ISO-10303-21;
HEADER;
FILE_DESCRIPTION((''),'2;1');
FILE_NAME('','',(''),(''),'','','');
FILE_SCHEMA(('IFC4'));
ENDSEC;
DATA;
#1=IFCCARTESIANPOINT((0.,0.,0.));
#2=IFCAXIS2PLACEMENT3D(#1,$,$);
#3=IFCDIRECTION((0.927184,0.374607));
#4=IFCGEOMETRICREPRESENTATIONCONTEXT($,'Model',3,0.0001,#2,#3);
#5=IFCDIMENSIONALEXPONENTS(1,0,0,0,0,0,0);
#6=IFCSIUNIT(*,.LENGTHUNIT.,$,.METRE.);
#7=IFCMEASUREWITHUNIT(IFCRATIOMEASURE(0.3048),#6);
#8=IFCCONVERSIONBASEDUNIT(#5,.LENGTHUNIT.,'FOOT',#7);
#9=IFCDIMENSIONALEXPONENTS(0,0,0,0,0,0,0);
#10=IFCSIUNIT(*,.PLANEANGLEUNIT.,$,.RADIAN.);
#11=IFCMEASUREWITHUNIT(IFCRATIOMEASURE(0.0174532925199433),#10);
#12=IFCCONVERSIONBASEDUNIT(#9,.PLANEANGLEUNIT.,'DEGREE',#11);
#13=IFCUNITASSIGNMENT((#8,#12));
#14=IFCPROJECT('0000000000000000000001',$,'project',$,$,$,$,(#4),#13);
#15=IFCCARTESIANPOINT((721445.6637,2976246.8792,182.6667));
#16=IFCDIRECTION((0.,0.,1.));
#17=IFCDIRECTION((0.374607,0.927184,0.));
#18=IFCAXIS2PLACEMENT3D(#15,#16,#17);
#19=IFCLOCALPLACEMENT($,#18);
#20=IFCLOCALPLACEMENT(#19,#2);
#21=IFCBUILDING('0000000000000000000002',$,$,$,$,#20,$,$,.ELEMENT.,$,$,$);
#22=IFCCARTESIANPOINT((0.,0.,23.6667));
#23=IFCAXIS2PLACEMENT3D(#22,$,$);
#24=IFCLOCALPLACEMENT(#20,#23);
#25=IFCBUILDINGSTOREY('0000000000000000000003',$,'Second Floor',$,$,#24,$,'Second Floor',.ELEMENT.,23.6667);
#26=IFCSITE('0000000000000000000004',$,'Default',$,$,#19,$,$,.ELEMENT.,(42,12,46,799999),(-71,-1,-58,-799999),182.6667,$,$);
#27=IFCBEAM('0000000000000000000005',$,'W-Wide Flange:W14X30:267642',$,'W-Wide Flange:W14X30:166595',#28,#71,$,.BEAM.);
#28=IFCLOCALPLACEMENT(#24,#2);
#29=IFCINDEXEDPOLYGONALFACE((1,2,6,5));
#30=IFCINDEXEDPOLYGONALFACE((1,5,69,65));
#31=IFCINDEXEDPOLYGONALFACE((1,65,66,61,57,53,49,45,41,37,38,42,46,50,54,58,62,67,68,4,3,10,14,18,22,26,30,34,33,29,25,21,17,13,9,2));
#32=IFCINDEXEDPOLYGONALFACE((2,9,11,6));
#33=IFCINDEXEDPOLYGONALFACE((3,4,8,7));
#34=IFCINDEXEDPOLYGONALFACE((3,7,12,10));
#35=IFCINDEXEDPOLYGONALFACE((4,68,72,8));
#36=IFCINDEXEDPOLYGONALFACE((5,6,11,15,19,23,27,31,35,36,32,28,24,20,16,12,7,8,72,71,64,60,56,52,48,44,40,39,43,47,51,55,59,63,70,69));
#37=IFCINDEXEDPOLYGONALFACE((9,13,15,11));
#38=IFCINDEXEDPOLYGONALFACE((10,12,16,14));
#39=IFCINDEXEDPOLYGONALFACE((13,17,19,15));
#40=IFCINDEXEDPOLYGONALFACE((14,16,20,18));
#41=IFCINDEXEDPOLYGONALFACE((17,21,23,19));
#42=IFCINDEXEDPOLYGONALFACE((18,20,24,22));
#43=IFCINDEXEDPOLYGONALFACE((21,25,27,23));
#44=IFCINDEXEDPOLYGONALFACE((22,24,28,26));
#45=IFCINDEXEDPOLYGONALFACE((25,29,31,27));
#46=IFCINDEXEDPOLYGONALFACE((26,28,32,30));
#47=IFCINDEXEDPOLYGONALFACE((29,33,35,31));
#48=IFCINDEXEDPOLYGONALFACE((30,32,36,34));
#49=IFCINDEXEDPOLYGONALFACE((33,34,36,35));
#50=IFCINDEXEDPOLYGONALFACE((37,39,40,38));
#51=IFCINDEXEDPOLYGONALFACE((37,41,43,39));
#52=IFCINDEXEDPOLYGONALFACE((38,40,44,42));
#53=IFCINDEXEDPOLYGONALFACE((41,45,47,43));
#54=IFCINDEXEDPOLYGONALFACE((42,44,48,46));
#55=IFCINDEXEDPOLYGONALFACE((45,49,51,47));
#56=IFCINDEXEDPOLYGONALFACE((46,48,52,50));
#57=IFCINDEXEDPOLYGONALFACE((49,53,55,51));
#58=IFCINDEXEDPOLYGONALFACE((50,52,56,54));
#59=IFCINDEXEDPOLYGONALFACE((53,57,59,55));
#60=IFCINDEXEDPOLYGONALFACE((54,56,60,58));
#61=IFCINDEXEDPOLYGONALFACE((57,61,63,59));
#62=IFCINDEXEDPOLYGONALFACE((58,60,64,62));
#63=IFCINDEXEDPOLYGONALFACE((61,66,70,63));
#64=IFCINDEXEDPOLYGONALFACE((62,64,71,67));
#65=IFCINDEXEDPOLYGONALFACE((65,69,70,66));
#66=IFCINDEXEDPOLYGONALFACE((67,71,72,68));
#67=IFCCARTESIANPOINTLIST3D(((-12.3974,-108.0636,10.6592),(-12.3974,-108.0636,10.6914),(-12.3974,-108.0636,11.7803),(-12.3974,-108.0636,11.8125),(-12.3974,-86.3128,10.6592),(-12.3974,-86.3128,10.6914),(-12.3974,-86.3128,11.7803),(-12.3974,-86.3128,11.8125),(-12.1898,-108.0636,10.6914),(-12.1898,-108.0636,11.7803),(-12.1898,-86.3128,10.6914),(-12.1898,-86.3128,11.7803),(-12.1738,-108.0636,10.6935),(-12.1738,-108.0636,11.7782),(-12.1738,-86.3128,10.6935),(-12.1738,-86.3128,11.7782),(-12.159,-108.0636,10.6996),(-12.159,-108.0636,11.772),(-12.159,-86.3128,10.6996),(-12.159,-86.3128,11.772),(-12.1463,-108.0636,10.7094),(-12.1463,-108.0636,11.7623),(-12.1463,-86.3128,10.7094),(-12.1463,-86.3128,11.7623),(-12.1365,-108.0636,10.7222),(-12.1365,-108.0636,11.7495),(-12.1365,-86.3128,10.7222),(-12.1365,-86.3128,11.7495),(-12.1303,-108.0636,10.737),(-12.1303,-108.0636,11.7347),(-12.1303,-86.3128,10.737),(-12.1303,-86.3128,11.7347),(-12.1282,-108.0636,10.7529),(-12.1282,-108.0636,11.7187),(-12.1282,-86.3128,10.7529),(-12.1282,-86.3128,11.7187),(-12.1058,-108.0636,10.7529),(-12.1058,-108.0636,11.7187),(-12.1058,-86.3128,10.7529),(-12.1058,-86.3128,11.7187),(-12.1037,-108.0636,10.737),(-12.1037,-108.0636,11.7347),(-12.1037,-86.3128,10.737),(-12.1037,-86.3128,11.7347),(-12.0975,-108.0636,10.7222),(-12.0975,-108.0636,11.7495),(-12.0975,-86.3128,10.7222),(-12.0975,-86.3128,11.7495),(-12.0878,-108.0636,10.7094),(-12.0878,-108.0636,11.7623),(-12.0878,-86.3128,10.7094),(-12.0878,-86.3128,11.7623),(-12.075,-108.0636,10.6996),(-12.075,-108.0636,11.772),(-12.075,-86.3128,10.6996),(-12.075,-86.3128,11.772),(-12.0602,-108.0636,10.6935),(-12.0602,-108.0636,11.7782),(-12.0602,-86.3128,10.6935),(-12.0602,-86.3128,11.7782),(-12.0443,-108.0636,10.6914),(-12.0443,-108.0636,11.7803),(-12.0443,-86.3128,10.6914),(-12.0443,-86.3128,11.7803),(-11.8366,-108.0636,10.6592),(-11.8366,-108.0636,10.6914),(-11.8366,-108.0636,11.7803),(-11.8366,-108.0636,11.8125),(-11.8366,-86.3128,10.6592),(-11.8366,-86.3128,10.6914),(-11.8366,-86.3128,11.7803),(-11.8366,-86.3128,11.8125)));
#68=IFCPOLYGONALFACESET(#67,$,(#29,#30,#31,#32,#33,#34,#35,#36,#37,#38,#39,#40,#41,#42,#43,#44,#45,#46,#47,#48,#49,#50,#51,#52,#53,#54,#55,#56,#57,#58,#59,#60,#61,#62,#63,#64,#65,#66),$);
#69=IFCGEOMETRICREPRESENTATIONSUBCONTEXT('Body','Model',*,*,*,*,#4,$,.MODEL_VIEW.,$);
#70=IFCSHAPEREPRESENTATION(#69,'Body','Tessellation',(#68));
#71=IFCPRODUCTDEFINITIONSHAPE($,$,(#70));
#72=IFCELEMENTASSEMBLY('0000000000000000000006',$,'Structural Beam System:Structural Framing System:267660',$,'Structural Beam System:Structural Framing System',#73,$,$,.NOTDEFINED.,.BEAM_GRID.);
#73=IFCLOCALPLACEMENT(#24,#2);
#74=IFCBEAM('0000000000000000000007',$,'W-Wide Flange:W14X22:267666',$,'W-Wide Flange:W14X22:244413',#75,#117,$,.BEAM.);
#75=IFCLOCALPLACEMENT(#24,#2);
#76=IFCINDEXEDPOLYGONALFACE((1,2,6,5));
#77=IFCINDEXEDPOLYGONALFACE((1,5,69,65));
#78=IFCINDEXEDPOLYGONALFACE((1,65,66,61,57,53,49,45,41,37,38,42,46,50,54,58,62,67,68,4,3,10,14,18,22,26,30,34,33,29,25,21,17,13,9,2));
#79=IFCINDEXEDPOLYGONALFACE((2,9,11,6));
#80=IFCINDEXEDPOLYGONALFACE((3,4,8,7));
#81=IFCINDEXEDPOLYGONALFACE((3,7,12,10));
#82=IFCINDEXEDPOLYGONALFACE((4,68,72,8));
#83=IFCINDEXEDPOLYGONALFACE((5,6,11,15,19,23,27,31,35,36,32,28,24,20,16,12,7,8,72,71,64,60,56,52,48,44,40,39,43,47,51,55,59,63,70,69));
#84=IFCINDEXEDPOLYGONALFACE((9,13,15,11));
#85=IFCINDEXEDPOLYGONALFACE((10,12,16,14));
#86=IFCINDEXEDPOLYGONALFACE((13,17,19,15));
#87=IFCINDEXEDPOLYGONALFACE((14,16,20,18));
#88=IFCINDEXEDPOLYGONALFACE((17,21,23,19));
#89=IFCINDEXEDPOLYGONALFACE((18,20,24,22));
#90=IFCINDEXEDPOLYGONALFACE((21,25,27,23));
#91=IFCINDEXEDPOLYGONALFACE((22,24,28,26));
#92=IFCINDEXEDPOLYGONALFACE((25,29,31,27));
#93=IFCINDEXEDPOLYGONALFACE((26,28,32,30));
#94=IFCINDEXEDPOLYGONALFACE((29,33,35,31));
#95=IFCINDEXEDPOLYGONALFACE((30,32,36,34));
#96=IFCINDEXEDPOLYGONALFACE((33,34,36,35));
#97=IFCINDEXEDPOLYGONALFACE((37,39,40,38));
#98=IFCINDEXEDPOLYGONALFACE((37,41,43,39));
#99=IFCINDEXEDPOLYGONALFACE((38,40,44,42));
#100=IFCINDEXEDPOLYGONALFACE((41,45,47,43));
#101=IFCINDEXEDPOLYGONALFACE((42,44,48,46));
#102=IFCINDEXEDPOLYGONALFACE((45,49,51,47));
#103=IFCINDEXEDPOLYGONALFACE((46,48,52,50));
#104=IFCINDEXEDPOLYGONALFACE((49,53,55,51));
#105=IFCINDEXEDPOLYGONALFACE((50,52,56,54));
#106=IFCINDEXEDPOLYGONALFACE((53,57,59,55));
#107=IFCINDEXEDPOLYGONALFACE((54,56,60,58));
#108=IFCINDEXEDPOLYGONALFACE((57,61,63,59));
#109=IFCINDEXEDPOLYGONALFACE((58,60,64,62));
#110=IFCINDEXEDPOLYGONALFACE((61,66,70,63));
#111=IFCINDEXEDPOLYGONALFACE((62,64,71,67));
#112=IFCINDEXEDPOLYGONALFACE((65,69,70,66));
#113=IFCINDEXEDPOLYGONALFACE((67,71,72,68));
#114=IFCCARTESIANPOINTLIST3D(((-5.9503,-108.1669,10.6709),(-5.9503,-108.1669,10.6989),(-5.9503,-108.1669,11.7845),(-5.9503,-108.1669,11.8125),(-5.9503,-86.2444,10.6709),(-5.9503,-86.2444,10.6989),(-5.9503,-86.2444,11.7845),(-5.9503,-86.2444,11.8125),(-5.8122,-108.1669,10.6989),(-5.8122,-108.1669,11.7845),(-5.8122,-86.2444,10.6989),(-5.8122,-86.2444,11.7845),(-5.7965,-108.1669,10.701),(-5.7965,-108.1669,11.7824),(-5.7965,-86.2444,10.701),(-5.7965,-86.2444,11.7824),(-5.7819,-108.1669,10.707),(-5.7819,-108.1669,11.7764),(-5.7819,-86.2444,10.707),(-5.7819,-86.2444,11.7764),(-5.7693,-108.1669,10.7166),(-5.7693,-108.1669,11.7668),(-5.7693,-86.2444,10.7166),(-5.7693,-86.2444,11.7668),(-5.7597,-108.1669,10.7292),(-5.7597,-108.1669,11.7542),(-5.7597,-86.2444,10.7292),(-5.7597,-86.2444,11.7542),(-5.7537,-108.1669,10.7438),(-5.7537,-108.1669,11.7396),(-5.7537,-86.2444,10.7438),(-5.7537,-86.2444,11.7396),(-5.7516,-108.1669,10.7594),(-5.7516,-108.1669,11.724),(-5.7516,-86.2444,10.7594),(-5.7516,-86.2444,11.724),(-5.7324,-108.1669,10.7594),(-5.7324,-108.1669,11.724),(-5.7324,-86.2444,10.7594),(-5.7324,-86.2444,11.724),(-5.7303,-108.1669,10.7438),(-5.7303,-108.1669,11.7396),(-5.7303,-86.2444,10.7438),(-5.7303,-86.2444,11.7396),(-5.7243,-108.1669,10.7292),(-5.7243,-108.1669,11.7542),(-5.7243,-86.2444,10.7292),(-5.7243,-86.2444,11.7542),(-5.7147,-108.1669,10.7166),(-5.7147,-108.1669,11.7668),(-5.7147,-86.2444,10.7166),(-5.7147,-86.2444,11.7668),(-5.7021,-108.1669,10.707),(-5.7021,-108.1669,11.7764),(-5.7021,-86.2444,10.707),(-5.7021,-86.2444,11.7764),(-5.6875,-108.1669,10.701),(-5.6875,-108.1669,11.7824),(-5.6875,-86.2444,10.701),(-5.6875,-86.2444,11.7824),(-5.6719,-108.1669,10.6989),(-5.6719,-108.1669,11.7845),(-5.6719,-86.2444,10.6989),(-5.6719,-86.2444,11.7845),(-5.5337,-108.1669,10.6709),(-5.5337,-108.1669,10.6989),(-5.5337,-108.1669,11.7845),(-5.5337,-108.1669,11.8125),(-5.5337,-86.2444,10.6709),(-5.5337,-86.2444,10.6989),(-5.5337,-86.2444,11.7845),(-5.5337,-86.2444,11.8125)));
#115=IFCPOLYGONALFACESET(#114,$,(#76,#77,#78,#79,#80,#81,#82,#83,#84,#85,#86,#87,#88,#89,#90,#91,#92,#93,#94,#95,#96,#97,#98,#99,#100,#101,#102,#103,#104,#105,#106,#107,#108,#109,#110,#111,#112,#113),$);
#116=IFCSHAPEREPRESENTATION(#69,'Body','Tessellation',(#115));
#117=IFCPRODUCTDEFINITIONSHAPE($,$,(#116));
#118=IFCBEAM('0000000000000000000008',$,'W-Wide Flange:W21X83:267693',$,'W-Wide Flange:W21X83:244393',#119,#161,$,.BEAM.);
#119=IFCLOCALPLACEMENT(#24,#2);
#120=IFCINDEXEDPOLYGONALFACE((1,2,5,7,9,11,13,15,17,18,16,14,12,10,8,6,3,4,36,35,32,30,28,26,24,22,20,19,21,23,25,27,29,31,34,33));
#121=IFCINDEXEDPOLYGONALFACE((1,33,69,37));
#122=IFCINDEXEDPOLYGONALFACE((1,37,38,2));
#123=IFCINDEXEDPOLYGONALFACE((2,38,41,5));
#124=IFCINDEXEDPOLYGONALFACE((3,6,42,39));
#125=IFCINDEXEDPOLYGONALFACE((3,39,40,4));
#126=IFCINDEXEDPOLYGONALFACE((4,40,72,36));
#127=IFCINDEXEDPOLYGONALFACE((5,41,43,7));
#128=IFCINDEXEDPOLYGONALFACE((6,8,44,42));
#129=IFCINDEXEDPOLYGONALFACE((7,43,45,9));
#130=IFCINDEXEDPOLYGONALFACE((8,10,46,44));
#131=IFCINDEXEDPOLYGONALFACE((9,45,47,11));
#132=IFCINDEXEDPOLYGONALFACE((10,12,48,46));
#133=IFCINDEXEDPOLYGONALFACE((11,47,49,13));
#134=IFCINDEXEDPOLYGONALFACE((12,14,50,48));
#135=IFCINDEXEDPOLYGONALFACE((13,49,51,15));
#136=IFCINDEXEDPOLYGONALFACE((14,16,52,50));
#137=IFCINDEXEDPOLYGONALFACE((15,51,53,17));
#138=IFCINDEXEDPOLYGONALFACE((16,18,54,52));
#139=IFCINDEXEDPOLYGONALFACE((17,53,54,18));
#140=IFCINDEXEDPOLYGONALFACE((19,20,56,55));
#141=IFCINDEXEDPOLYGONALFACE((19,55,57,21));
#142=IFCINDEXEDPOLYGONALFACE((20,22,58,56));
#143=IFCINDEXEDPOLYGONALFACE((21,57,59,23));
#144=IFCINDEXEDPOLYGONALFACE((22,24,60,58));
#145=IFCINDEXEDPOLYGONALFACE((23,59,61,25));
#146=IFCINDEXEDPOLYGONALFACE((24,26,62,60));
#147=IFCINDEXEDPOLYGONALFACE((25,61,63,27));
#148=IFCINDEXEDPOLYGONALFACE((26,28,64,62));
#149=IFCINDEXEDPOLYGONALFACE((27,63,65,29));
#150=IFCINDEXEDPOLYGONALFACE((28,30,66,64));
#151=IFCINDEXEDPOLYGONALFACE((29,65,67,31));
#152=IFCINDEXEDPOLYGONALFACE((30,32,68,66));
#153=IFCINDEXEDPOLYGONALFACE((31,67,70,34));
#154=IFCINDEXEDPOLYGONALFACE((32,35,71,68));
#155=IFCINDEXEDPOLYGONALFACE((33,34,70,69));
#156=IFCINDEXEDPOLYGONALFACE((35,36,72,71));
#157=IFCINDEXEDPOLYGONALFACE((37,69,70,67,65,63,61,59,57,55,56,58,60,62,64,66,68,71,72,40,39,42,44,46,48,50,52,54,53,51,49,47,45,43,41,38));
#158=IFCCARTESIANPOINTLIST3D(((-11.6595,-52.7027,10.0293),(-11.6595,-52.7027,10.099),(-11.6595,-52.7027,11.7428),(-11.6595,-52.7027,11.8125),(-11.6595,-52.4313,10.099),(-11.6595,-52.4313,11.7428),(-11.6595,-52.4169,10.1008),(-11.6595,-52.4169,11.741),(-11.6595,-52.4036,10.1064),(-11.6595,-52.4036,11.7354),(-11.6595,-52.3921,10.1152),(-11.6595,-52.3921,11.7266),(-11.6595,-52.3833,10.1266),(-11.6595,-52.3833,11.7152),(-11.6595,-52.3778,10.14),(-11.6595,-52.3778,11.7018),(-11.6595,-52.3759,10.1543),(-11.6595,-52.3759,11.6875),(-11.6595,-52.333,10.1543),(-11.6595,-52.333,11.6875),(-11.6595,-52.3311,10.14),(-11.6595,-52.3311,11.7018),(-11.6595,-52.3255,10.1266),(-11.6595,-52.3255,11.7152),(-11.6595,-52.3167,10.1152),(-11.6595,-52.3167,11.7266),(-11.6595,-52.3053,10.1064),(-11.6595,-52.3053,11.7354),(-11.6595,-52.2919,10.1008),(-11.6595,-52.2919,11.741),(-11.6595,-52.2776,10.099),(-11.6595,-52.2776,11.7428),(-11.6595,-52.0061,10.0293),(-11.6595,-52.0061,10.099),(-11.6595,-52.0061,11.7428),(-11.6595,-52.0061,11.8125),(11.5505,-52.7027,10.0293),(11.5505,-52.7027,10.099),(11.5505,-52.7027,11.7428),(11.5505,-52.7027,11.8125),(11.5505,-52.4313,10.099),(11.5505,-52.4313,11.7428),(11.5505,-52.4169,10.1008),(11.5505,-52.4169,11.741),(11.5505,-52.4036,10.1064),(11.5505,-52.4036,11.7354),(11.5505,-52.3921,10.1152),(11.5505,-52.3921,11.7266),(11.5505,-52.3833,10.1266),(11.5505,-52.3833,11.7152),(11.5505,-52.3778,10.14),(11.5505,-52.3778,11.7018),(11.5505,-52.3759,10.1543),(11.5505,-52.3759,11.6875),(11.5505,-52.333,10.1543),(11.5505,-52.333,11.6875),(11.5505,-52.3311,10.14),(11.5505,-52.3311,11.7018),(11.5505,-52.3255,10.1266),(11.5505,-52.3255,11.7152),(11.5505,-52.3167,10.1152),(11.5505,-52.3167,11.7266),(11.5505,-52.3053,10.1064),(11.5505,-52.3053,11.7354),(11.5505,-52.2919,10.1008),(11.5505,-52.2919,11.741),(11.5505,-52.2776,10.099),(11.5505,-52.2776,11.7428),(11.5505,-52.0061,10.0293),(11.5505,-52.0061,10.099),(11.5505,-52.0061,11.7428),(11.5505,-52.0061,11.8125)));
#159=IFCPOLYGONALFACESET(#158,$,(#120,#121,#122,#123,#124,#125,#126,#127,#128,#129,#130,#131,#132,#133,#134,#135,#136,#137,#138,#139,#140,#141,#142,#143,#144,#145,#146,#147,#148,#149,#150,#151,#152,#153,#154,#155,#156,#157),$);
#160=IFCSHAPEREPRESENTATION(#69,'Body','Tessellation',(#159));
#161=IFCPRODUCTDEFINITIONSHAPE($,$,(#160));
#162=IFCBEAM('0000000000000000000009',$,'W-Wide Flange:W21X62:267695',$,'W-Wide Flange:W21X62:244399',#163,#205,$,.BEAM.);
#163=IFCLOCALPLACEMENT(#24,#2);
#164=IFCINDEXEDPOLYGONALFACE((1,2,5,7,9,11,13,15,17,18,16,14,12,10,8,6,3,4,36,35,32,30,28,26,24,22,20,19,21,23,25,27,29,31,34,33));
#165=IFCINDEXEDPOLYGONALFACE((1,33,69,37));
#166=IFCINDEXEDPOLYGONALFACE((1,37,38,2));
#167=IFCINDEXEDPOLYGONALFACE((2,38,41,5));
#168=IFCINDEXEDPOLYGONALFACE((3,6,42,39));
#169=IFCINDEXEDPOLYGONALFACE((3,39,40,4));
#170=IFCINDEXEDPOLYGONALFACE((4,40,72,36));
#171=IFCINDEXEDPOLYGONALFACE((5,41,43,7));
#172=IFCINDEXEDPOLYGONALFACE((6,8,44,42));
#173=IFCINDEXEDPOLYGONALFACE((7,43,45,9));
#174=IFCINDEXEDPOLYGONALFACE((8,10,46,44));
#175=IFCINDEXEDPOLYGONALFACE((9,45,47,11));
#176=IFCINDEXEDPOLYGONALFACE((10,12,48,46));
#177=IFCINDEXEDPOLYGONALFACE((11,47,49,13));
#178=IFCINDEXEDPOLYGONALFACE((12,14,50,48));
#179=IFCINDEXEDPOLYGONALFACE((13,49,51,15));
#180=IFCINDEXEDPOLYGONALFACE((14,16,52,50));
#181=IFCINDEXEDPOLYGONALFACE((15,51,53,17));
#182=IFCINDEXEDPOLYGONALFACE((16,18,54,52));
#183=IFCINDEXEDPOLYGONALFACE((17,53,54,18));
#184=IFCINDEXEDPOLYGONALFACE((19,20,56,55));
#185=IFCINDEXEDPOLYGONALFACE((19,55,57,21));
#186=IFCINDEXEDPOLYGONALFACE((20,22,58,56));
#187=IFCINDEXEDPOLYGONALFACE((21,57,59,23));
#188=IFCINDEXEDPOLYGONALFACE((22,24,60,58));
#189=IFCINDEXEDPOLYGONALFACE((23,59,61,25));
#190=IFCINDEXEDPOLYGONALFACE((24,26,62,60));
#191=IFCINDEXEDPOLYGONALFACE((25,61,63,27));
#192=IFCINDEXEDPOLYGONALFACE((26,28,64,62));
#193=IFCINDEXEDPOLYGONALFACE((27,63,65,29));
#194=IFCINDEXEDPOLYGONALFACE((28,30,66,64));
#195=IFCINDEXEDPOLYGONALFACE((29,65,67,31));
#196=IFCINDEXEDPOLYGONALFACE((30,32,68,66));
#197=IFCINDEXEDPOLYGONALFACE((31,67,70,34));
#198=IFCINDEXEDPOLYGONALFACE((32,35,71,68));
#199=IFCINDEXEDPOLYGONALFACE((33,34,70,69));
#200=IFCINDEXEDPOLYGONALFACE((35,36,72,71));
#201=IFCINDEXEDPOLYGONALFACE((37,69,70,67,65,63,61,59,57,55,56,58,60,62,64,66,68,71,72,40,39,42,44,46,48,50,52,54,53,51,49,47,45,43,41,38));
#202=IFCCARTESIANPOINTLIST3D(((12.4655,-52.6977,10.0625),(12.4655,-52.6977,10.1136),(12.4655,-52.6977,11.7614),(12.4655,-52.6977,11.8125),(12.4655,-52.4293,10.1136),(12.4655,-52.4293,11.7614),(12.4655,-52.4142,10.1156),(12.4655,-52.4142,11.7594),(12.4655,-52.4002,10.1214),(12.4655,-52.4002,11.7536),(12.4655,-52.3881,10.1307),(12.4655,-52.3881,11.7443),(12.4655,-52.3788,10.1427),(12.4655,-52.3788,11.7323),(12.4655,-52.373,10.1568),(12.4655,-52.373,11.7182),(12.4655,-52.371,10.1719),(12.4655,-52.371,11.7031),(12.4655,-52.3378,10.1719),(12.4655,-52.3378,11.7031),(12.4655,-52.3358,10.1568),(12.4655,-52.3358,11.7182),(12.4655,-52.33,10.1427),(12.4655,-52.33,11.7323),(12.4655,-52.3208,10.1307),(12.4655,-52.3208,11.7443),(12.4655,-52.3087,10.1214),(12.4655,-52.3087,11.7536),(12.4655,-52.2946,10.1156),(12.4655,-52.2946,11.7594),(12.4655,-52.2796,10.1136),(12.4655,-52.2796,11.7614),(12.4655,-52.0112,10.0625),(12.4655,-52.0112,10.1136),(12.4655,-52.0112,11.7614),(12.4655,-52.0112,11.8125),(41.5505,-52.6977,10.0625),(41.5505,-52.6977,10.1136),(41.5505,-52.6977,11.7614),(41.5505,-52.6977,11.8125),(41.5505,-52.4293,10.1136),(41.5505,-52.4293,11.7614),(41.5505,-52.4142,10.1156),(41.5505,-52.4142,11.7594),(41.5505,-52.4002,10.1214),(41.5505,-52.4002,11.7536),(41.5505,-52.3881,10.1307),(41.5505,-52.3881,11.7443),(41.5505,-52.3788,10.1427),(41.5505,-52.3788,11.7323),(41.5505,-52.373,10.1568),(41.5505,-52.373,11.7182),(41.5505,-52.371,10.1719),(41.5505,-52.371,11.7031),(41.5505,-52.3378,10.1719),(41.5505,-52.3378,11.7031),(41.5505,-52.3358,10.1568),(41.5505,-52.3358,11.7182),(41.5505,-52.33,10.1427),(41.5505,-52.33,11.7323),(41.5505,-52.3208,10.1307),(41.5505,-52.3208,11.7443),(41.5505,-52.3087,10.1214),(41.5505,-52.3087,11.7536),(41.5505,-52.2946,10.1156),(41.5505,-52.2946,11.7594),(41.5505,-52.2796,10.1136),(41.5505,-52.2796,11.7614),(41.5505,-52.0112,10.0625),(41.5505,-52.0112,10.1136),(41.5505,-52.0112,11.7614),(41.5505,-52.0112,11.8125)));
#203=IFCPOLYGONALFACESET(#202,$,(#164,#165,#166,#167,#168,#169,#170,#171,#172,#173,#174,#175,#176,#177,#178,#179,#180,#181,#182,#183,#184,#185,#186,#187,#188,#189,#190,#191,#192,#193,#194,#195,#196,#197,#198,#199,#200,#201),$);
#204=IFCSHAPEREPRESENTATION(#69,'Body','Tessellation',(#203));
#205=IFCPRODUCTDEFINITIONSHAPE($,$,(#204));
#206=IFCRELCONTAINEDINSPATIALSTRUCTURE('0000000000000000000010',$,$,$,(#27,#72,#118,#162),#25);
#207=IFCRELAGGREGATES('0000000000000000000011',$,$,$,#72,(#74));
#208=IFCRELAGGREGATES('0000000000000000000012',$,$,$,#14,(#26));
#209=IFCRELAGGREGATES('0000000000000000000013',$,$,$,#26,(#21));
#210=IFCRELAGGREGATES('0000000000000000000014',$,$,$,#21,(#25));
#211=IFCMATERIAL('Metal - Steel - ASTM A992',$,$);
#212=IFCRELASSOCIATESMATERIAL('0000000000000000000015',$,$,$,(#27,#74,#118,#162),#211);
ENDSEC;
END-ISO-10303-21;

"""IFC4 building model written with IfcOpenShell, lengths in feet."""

from ifc_helpers import new_model, entity, si_unit, converted_unit, direction, frame, frame_2d, origin, place, context, subcontext, project, spatial, i_section, extrude, material, element, aggregate, save


model = new_model("IFC4")

# Units and contexts
model_context = context("Model", 3, precision=0.0001, world=origin(), true_north=direction((0.927184, 0.374607)))
body_context = subcontext(model_context, "Body", "Model", "MODEL_VIEW")
ifc_project = project(units=[converted_unit("LENGTHUNIT", "FOOT", entity("IfcRatioMeasure", 0.3048), si_unit("LENGTHUNIT", "METRE"), dimensions=[1, 0, 0, 0, 0, 0, 0]), converted_unit("PLANEANGLEUNIT", "DEGREE", entity("IfcRatioMeasure", 0.0174532925199433), si_unit("PLANEANGLEUNIT", "RADIAN"), dimensions=[0, 0, 0, 0, 0, 0, 0])], contexts=[model_context])

# Site, building, storey
site_placement = place(None, frame((721445.6637, 2976246.8792, 182.6667), z_axis=(0.0, 0.0, 1.0), x_axis=(0.374607, 0.927184, 0.0)))
site = spatial("IfcSite", under=ifc_project, at=site_placement, Name="Default", CompositionType="ELEMENT", RefLatitude=(42, 12, 46, 799999), RefLongitude=(-71, -1, -58, -799999), RefElevation=182.6667)
building_placement = place(site_placement, origin())
building = spatial("IfcBuilding", under=site, at=building_placement, CompositionType="ELEMENT")
storey_placement = place(building_placement, frame((0.0, 0.0, 23.6667)))
storey = spatial("IfcBuildingStorey", under=building, at=storey_placement, Name="Second Floor", LongName="Second Floor", CompositionType="ELEMENT", Elevation=23.6667)

# Shared definitions
ifc_material_1 = material(Name="Metal - Steel - ASTM A992")

# Beam
beam_1_placement = place(storey_placement, frame((-12.117, -85.8544, 11.8125), z_axis=(0.0, 0.0, 1.0), x_axis=(0.0, -1.0, 0.0)))
element("IfcBeam", 1, at=beam_1_placement, inside=storey, material=ifc_material_1, Name="W-Wide Flange:W14X30:267642", ObjectType="W-Wide Flange:W14X30:166595", PredefinedType="BEAM", context=body_context, shape_type="SweptSolid", body=[
    extrude(i_section(OverallWidth=0.5609, OverallDepth=1.1533, WebThickness=0.0225, FlangeThickness=0.0322, FilletRadius=0.0615, at=frame_2d((0.0, 0.0), x_axis=(0.0, 1.0))), frame((0.4583, 0.0, -0.5767), z_axis=(1.0, 0.0, 0.0), x_axis=(0.0, 0.0, -1.0)), (0.0, 0.0, 1.0), 21.7508),
])

# Element assembly, beam
assembly_1_placement = place(storey_placement, origin())
assembly_1 = element("IfcElementAssembly", 2, at=assembly_1_placement, inside=storey, Name="Structural Beam System:Structural Framing System:267660", ObjectType="Structural Beam System:Structural Framing System", AssemblyPlace="NOTDEFINED", PredefinedType="BEAM_GRID")
beam_2_placement = place(assembly_1_placement, frame((-5.742, -85.8544, 11.8125), z_axis=(0.0, 0.0, 1.0), x_axis=(0.0, -1.0, 0.0)))
beam_2 = element("IfcBeam", 3, at=beam_2_placement, material=ifc_material_1, Name="W-Wide Flange:W14X22:267666", ObjectType="W-Wide Flange:W14X22:244413", PredefinedType="BEAM", context=body_context, shape_type="SweptSolid", body=[
    extrude(i_section(OverallWidth=0.4167, OverallDepth=1.1416, WebThickness=0.0192, FlangeThickness=0.028, FilletRadius=0.0605, at=frame_2d((0.0, 0.0), x_axis=(0.0, 1.0))), frame((0.39, 0.0, -0.5708), z_axis=(1.0, 0.0, 0.0), x_axis=(0.0, 0.0, -1.0)), (0.0, 0.0, 1.0), 21.9225),
])
aggregate(assembly_1, [beam_2])

# Beams
beam_3_placement = place(storey_placement, frame((-12.117, -52.3544, 11.8125)))
element("IfcBeam", 4, at=beam_3_placement, inside=storey, material=ifc_material_1, Name="W-Wide Flange:W21X83:267693", ObjectType="W-Wide Flange:W21X83:244393", PredefinedType="BEAM", context=body_context, shape_type="SweptSolid", body=[
    extrude(i_section(OverallWidth=0.6966, OverallDepth=1.7832, WebThickness=0.043, FlangeThickness=0.0697, FilletRadius=0.0553, at=frame_2d((0.0, 0.0), x_axis=(0.0, 1.0))), frame((0.4575, 0.0, -0.8916), z_axis=(1.0, 0.0, 0.0), x_axis=(0.0, 0.0, -1.0)), (0.0, 0.0, 1.0), 23.21),
])
beam_4_placement = place(storey_placement, frame((12.008, -52.3544, 11.8125)))
element("IfcBeam", 5, at=beam_4_placement, inside=storey, material=ifc_material_1, Name="W-Wide Flange:W21X62:267695", ObjectType="W-Wide Flange:W21X62:244399", PredefinedType="BEAM", context=body_context, shape_type="SweptSolid", body=[
    extrude(i_section(OverallWidth=0.6865, OverallDepth=1.75, WebThickness=0.0332, FlangeThickness=0.0511, FilletRadius=0.0583, at=frame_2d((0.0, 0.0), x_axis=(0.0, 1.0))), frame((0.4575, 0.0, -0.875), z_axis=(1.0, 0.0, 0.0), x_axis=(0.0, 0.0, -1.0)), (0.0, 0.0, 1.0), 29.085),
])

save(model, "model.ifc")
